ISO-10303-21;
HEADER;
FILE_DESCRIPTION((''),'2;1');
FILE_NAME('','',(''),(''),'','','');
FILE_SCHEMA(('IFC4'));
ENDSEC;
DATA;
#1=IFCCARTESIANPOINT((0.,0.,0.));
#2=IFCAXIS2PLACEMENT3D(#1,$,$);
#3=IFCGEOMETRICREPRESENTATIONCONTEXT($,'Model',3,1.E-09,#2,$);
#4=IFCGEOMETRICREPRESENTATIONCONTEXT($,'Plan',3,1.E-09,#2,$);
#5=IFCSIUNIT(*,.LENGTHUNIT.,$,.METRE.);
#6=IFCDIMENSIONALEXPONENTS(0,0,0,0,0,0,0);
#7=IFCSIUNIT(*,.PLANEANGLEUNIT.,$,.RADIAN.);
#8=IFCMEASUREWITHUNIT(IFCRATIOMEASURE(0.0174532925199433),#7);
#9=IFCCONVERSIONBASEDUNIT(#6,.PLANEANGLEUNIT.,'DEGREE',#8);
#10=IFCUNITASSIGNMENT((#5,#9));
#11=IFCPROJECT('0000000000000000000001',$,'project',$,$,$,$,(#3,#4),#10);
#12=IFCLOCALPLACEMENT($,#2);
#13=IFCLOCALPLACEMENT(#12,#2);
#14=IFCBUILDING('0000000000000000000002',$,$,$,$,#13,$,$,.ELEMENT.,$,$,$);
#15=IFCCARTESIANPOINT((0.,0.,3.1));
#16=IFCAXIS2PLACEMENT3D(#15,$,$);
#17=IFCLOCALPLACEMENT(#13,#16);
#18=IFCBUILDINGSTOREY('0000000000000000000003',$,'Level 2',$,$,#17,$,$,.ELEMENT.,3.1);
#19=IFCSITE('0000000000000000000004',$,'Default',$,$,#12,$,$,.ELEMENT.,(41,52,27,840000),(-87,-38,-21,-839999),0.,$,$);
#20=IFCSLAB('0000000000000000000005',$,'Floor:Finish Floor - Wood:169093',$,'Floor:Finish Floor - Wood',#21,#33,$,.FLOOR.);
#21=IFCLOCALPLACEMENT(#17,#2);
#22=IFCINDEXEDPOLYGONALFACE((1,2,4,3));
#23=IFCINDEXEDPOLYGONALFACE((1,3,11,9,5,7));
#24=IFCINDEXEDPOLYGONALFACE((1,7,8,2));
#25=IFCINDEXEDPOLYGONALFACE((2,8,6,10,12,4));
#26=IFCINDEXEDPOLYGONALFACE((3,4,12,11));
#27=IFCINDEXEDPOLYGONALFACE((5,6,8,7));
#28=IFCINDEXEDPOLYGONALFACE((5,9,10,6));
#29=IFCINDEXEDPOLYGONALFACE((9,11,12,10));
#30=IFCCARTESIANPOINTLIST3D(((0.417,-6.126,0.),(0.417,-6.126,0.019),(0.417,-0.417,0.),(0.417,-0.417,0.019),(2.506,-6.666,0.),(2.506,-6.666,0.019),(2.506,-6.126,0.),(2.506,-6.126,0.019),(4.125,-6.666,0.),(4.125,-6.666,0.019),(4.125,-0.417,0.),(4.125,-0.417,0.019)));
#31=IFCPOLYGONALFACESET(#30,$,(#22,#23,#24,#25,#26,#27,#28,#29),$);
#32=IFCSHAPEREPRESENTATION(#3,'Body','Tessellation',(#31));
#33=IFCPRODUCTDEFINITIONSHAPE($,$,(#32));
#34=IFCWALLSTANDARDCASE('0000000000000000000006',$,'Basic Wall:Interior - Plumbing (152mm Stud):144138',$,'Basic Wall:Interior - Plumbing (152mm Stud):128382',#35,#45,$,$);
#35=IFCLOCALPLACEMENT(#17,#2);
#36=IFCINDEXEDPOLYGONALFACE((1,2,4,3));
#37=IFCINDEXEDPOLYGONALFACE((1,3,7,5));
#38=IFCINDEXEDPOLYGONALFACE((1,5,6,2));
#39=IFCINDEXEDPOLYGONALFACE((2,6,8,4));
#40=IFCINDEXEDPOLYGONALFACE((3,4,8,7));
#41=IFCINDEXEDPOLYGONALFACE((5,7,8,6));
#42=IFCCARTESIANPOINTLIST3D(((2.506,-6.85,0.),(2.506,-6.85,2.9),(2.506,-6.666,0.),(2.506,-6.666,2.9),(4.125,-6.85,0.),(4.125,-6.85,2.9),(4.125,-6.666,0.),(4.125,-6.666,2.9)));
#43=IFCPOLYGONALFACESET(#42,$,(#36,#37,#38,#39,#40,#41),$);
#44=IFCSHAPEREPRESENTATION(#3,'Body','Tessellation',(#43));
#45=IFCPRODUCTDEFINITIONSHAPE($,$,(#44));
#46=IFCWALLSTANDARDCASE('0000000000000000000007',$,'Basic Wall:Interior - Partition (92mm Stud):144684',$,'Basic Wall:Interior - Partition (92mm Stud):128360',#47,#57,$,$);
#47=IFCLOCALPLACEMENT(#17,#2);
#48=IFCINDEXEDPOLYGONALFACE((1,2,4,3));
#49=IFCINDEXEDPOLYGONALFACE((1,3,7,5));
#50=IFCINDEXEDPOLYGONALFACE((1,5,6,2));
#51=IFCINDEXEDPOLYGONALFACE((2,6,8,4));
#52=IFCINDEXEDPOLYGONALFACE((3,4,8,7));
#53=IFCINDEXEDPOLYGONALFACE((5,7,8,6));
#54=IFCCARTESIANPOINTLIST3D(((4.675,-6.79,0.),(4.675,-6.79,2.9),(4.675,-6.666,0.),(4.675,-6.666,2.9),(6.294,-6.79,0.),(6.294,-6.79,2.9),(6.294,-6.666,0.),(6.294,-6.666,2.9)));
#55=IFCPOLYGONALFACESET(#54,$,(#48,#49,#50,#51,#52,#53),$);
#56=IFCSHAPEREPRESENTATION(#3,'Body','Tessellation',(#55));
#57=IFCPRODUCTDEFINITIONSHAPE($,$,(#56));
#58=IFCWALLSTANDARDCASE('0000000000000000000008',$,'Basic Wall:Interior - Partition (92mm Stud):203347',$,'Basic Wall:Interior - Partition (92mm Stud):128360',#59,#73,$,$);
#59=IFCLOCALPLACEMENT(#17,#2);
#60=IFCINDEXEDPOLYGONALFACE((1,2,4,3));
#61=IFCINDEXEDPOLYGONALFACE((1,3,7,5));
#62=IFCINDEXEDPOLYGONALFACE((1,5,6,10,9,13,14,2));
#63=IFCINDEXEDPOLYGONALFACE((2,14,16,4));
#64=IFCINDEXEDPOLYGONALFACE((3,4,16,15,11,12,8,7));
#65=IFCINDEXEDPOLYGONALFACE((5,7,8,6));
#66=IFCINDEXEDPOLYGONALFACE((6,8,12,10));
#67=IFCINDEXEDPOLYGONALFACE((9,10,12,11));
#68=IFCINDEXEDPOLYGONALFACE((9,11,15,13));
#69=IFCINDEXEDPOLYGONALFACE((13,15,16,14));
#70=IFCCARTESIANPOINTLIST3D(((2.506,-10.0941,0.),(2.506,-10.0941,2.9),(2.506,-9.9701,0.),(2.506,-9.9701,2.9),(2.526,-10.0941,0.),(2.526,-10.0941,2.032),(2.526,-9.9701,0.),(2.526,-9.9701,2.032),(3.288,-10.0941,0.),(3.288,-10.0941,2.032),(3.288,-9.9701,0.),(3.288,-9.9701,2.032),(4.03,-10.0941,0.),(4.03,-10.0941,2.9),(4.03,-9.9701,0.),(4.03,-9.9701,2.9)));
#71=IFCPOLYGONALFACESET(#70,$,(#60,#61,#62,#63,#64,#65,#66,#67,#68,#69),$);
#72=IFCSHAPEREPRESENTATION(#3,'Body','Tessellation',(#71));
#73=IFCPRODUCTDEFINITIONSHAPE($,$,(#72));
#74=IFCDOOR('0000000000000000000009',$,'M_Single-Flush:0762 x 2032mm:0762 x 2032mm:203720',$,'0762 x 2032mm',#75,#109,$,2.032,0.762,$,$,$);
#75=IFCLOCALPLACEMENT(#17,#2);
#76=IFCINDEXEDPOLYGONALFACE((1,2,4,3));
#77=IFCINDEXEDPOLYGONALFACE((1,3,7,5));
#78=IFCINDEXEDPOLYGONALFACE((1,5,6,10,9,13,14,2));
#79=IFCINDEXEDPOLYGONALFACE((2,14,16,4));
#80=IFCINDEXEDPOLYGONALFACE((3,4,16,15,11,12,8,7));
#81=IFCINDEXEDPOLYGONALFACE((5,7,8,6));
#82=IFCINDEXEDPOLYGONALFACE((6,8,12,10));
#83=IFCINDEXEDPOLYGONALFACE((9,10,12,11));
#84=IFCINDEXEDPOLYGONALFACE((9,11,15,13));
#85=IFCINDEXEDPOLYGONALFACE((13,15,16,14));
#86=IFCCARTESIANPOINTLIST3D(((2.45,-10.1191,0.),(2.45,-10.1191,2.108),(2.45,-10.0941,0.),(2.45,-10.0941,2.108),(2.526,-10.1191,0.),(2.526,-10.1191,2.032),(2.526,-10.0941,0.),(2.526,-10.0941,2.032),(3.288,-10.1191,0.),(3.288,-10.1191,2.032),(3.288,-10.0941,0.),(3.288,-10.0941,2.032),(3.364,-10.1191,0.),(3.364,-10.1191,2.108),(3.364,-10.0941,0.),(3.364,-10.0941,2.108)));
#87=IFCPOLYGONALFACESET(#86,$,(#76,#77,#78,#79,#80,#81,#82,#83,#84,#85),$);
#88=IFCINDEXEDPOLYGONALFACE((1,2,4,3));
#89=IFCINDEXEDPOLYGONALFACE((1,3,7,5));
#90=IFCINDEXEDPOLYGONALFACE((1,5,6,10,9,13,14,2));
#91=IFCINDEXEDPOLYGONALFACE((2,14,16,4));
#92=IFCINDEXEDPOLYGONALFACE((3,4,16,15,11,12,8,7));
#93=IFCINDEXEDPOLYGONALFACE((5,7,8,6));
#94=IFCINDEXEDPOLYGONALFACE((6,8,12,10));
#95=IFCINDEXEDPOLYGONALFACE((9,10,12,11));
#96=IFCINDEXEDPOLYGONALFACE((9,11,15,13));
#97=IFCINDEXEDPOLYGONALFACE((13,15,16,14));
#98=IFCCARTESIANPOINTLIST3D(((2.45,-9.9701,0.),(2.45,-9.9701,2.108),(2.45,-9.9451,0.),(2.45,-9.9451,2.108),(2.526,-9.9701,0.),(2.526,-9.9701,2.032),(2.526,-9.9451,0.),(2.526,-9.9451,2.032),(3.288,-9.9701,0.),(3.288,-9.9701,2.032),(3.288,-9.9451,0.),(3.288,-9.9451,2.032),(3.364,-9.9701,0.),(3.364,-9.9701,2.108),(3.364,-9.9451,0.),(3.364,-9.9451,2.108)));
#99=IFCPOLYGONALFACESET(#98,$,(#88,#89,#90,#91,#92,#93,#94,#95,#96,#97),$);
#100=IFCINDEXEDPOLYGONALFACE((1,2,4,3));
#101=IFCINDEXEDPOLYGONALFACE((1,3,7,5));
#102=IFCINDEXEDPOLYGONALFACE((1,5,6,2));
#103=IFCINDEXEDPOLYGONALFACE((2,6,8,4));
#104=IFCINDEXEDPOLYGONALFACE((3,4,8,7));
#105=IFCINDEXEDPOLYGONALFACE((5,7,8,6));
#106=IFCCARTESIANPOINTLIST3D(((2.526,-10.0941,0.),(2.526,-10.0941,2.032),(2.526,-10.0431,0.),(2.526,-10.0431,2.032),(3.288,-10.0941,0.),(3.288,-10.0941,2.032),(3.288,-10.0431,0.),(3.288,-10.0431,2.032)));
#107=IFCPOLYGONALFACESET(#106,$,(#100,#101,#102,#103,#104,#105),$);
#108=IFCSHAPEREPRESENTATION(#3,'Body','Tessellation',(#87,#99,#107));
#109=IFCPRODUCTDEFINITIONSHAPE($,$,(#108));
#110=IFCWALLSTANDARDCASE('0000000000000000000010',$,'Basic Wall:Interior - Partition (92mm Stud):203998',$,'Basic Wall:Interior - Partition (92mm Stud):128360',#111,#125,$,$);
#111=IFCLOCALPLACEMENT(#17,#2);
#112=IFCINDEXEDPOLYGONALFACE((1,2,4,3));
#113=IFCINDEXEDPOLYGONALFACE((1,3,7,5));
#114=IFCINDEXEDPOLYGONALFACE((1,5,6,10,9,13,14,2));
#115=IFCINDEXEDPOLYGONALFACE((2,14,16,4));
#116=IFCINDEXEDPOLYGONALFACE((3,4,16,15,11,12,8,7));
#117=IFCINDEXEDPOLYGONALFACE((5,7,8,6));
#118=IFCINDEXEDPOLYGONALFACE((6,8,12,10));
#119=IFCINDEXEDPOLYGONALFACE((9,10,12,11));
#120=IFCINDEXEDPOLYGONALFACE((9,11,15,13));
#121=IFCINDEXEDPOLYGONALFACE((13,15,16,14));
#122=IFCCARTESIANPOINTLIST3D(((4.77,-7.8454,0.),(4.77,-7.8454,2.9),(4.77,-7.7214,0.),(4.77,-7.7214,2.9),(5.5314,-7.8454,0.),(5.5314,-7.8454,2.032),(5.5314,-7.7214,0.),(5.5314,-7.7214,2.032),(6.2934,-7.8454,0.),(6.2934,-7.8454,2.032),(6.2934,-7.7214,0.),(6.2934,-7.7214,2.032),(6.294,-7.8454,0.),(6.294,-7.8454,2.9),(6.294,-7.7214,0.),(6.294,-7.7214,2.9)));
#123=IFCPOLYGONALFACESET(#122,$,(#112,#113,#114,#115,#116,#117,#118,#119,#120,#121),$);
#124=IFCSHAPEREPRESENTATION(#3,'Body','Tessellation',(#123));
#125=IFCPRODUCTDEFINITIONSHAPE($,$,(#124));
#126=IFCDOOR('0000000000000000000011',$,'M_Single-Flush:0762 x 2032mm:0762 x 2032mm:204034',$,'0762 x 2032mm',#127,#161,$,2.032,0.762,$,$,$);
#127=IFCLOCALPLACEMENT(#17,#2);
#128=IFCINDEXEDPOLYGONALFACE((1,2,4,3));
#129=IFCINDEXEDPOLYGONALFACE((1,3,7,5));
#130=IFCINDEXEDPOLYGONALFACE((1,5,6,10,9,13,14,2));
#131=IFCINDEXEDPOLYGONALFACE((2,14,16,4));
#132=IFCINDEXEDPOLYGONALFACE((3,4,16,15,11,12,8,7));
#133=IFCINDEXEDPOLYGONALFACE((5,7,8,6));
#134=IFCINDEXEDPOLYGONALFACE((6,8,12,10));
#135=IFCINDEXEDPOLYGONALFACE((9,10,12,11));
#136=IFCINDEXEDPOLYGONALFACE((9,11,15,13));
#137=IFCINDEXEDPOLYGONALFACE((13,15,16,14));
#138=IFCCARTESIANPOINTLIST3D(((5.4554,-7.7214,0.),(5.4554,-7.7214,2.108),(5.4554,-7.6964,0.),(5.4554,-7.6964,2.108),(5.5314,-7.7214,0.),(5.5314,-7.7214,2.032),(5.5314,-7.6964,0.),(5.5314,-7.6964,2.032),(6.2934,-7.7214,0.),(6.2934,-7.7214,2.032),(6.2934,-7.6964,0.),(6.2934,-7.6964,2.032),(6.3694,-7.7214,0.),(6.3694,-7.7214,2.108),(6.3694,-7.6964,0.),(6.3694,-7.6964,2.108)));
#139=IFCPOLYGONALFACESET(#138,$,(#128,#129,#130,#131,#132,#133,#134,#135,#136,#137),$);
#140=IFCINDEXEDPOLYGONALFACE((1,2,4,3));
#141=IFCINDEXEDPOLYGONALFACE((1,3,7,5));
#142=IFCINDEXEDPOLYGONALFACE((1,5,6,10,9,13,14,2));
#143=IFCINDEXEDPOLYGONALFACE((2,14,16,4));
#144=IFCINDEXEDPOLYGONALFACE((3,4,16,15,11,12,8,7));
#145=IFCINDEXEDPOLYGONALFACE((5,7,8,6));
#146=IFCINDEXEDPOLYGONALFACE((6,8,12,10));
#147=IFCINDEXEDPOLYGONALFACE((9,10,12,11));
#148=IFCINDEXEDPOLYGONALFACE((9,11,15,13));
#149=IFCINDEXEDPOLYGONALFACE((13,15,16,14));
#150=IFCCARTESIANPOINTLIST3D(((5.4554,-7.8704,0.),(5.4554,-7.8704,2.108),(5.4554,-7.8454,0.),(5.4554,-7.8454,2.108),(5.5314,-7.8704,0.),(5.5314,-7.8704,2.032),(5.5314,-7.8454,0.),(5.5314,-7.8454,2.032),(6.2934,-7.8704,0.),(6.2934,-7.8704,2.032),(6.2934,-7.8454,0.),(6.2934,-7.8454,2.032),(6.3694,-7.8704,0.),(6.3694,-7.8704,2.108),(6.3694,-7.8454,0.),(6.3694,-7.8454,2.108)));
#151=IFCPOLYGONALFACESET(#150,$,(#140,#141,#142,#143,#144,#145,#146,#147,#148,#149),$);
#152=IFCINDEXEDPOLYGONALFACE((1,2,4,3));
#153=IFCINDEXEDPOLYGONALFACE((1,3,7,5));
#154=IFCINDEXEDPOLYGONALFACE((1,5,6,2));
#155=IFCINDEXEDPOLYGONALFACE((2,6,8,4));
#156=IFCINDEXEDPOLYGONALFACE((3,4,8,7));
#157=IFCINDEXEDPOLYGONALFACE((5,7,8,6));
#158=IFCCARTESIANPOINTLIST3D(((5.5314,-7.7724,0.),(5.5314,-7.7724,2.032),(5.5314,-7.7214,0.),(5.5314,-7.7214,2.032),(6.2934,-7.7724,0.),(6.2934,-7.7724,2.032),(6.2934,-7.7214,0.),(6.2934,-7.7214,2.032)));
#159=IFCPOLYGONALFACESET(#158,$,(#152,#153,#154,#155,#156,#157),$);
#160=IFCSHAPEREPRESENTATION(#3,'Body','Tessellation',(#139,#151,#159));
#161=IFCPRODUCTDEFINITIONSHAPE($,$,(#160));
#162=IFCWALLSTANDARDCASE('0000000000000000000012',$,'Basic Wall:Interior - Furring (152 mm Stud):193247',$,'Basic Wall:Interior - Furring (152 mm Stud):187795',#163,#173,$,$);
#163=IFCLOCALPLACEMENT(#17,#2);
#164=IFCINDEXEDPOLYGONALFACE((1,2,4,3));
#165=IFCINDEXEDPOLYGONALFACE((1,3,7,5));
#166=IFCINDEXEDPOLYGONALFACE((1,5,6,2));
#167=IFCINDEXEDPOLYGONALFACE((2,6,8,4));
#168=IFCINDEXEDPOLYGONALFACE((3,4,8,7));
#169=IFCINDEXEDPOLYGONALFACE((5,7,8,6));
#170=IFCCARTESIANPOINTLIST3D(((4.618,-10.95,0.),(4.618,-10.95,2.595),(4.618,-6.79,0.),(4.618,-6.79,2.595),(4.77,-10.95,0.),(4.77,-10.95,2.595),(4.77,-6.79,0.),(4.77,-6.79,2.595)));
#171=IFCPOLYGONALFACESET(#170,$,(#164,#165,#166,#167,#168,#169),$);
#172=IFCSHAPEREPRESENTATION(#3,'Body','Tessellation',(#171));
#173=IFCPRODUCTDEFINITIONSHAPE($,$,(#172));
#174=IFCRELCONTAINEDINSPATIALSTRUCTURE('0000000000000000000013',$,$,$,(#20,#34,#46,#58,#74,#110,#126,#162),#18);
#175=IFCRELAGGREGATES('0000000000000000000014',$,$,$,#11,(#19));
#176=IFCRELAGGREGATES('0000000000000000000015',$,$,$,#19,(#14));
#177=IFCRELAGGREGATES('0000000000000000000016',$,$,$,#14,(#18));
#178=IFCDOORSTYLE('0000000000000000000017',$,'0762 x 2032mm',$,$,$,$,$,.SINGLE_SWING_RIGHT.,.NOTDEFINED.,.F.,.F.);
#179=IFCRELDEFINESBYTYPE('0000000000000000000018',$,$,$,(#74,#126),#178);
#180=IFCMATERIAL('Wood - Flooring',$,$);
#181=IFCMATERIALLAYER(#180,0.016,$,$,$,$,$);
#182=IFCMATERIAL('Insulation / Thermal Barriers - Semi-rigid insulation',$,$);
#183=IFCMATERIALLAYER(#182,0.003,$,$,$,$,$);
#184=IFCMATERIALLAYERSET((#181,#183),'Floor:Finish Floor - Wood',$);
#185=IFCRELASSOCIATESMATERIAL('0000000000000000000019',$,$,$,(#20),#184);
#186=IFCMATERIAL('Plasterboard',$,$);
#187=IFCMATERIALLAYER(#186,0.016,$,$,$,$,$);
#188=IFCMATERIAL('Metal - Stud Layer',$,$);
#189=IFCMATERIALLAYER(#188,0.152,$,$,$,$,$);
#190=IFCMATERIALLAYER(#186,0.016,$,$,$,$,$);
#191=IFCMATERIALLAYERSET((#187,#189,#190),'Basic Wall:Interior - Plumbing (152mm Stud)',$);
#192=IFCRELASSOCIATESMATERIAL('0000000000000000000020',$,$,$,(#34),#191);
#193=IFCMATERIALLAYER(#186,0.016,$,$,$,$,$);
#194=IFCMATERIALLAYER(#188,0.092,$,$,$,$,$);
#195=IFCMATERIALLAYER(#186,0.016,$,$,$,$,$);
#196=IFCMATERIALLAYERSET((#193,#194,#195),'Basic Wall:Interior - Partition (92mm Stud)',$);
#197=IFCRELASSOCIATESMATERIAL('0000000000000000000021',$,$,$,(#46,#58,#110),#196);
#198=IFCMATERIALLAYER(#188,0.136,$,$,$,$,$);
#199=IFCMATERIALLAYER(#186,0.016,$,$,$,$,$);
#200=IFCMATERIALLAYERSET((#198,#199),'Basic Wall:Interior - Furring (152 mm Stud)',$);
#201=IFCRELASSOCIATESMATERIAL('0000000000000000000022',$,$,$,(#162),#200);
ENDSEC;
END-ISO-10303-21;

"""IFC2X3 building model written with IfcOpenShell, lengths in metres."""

from ifc_helpers import new_model, entity, si_unit, converted_unit, frame, frame_2d, origin, origin_2d_with_axis, place, context, project, spatial, polyline, rectangle, outline, extrude, source, transform, mapped, material, layer, layer_set, layer_usage, type_object, type_shapes, element, fill, save


model = new_model("IFC2X3")

# Units and contexts
model_context = context("Model", 3, precision=1e-09, world=origin())
plan_context = context("Plan", 3, precision=1e-09, world=origin())
ifc_project = project(units=[si_unit("LENGTHUNIT", "METRE"), converted_unit("PLANEANGLEUNIT", "DEGREE", entity("IfcRatioMeasure", 0.0174532925199433), si_unit("PLANEANGLEUNIT", "RADIAN"), dimensions=[0, 0, 0, 0, 0, 0, 0])], contexts=[model_context, plan_context])

# Site, building, storey
site_placement = place(None, origin())
site = spatial("IfcSite", under=ifc_project, at=site_placement, Name="Default", CompositionType="ELEMENT", RefLatitude=(41, 52, 27, 840000), RefLongitude=(-87, -38, -21, -839999), RefElevation=0.0)
building_placement = place(site_placement, origin())
building = spatial("IfcBuilding", under=site, at=building_placement, CompositionType="ELEMENT")
storey_placement = place(building_placement, frame((0.0, 0.0, 3.1)))
storey = spatial("IfcBuildingStorey", under=building, at=storey_placement, Name="Level 2", CompositionType="ELEMENT", Elevation=3.1)

# Slab
ifc_material_1 = material(Name="Wood - Flooring")
ifc_layer_1 = layer(ifc_material_1, 0.016)
ifc_material_2 = material(Name="Insulation / Thermal Barriers - Semi-rigid insulation")
ifc_layer_2 = layer(ifc_material_2, 0.003)
ifc_layer_set_1 = layer_set([ifc_layer_1, ifc_layer_2], Name="Floor:Finish Floor - Wood")
ifc_layer_usage_1 = layer_usage(ifc_layer_set_1, "AXIS3", "POSITIVE", 0.0)
slab_placement = place(storey_placement, frame((0.417, -6.666, 0.0)))
element("IfcSlab", 1, at=slab_placement, inside=storey, material=ifc_layer_usage_1, Name="Floor:Finish Floor - Wood:169093", ObjectType="Floor:Finish Floor - Wood", PredefinedType="FLOOR", context=model_context, shape_type="SweptSolid", body=[
    extrude(outline(polyline([(1.854, 3.1245), (-1.854, 3.1245), (-1.854, -3.1245), (-0.235, -3.1245), (-0.235, -2.5845), (1.854, -2.5845), (1.854, 3.1245)])), frame((1.854, 3.1245, 0.019), z_axis=(0.0, 0.0, -1.0), x_axis=(-1.0, 0.0, 0.0)), (0.0, 0.0, 1.0), 0.019),
])

# Walls
ifc_material_3 = material(Name="Plasterboard")
ifc_layer_3 = layer(ifc_material_3, 0.016)
ifc_material_4 = material(Name="Metal - Stud Layer")
ifc_layer_4 = layer(ifc_material_4, 0.152)
ifc_layer_5 = layer(ifc_material_3, 0.016)
ifc_layer_set_2 = layer_set([ifc_layer_3, ifc_layer_4, ifc_layer_5], Name="Basic Wall:Interior - Plumbing (152mm Stud)")
ifc_layer_usage_2 = layer_usage(ifc_layer_set_2, "AXIS2", "NEGATIVE", 0.092)
wall_1_placement = place(storey_placement, frame((2.506, -6.758, 0.0)))
element("IfcWallStandardCase", 2, at=wall_1_placement, inside=storey, material=ifc_layer_usage_2, Name="Basic Wall:Interior - Plumbing (152mm Stud):144138", ObjectType="Basic Wall:Interior - Plumbing (152mm Stud):128382", context=model_context, shape_type="SweptSolid", body=[
    extrude(rectangle(XDim=1.619, YDim=0.184, at=frame_2d((0.8095, 0.0), x_axis=(-1.0, 0.0))), origin(), (0.0, 0.0, 1.0), 2.9),
])
ifc_layer_6 = layer(ifc_material_3, 0.016)
ifc_layer_7 = layer(ifc_material_4, 0.092)
ifc_layer_8 = layer(ifc_material_3, 0.016)
ifc_layer_set_3 = layer_set([ifc_layer_6, ifc_layer_7, ifc_layer_8], Name="Basic Wall:Interior - Partition (92mm Stud)")
ifc_layer_usage_3 = layer_usage(ifc_layer_set_3, "AXIS2", "NEGATIVE", 0.062)
wall_2_placement = place(storey_placement, frame((4.675, -6.728, 0.0)))
element("IfcWallStandardCase", 3, at=wall_2_placement, inside=storey, material=ifc_layer_usage_3, Name="Basic Wall:Interior - Partition (92mm Stud):144684", ObjectType="Basic Wall:Interior - Partition (92mm Stud):128360", context=model_context, shape_type="SweptSolid", body=[
    extrude(rectangle(XDim=1.619, YDim=0.124, at=frame_2d((0.8095, 0.0), x_axis=(-1.0, 0.0))), origin(), (0.0, 0.0, 1.0), 2.9),
])

# Walls, openings, doors
wall_3_placement = place(storey_placement, frame((4.03, -10.0321, 0.0), z_axis=(0.0, 0.0, 1.0), x_axis=(-1.0, 0.0, 0.0)))
wall_3 = element("IfcWallStandardCase", 4, at=wall_3_placement, inside=storey, material=ifc_layer_usage_3, Name="Basic Wall:Interior - Partition (92mm Stud):203347", ObjectType="Basic Wall:Interior - Partition (92mm Stud):128360", context=model_context, shape_type="SweptSolid", body=[
    extrude(rectangle(XDim=1.524, YDim=0.124, at=frame_2d((0.762, 0.0), x_axis=(-1.0, 0.0))), origin(), (0.0, 0.0, 1.0), 2.9),
])
opening_1_placement = place(wall_3_placement, frame((0.742, -0.062, 0.0)))
opening_1 = element("IfcOpeningElement", 5, at=opening_1_placement, cuts=wall_3, ObjectType="Opening", context=model_context, shape_type="SweptSolid", body=[
    extrude(rectangle(XDim=0.762, YDim=2.032, at=frame_2d((1.016, 0.381), x_axis=(0.0, 1.0))), frame((0.0, 0.0, 0.0), z_axis=(0.0, 1.0, 0.0), x_axis=(0.0, 0.0, 1.0)), (0.0, 0.0, 1.0), 0.124),
])
door_style = type_object("IfcDoorStyle", Name="0762 x 2032mm", ConstructionType="NOTDEFINED", OperationType="SINGLE_SWING_RIGHT", ParameterTakesPrecedence=False, Sizeable=False)
shared_shape = source(origin(), model_context, "Body", "SweptSolid", [
    extrude(outline(polyline([(-0.457, -1.073), (0.457, -1.073), (0.457, 1.035), (0.381, 1.035), (0.381, -0.997), (-0.381, -0.997), (-0.381, 1.035), (-0.457, 1.035), (-0.457, -1.073)])), frame((0.381, 0.124, 1.035), z_axis=(0.0, 1.0, 0.0), x_axis=(1.0, 0.0, 0.0)), (0.0, 0.0, 1.0), 0.025),
    extrude(outline(polyline([(-1.073, -0.457), (1.035, -0.457), (1.035, -0.381), (-0.997, -0.381), (-0.997, 0.381), (1.035, 0.381), (1.035, 0.457), (-1.073, 0.457), (-1.073, -0.457)])), frame((0.381, -0.025, 1.035), z_axis=(0.0, 1.0, 0.0), x_axis=(0.0, 0.0, -1.0)), (0.0, 0.0, 1.0), 0.025),
    extrude(rectangle(XDim=0.051, YDim=0.762, at=origin_2d_with_axis()), frame((0.381, 0.0985, 0.0), z_axis=(0.0, 0.0, 1.0), x_axis=(0.0, 1.0, 0.0)), (0.0, 0.0, 1.0), 2.032),
])
type_shapes(door_style, [shared_shape])
door_1_placement = place(opening_1_placement, origin())
door_1 = element("IfcDoor", 6, at=door_1_placement, inside=storey, type_object=door_style, Name="M_Single-Flush:0762 x 2032mm:0762 x 2032mm:203720", ObjectType="0762 x 2032mm", OverallHeight=2.032, OverallWidth=0.762, context=model_context, shape_type="MappedRepresentation", body=[
    mapped(shared_shape, transform((0.0, 0.0, 0.0), scale=1.0)),
])
fill(opening_1, door_1)
ifc_layer_usage_4 = layer_usage(ifc_layer_set_3, "AXIS2", "POSITIVE", -0.062)
wall_4_placement = place(storey_placement, frame((4.77, -7.7834, 0.0)))
wall_4 = element("IfcWallStandardCase", 7, at=wall_4_placement, inside=storey, material=ifc_layer_usage_4, Name="Basic Wall:Interior - Partition (92mm Stud):203998", ObjectType="Basic Wall:Interior - Partition (92mm Stud):128360", context=model_context, shape_type="SweptSolid", body=[
    extrude(rectangle(XDim=1.524, YDim=0.124, at=frame_2d((0.762, 0.0), x_axis=(-1.0, 0.0))), origin(), (0.0, 0.0, 1.0), 2.9),
])
opening_2_placement = place(wall_4_placement, frame((0.7614, -0.062, 0.0)))
opening_2 = element("IfcOpeningElement", 8, at=opening_2_placement, cuts=wall_4, ObjectType="Opening", context=model_context, shape_type="SweptSolid", body=[
    extrude(rectangle(XDim=0.762, YDim=2.032, at=frame_2d((1.016, 0.381), x_axis=(0.0, 1.0))), frame((0.0, 0.0, 0.0), z_axis=(0.0, 1.0, 0.0), x_axis=(0.0, 0.0, 1.0)), (0.0, 0.0, 1.0), 0.124),
])
door_2_placement = place(opening_2_placement, origin())
door_2 = element("IfcDoor", 9, at=door_2_placement, inside=storey, type_object=door_style, Name="M_Single-Flush:0762 x 2032mm:0762 x 2032mm:204034", ObjectType="0762 x 2032mm", OverallHeight=2.032, OverallWidth=0.762, context=model_context, shape_type="MappedRepresentation", body=[
    mapped(shared_shape, transform((0.0, 0.0, 0.0), scale=1.0)),
])
fill(opening_2, door_2)

# Wall
ifc_layer_9 = layer(ifc_material_4, 0.136)
ifc_layer_10 = layer(ifc_material_3, 0.016)
ifc_layer_set_4 = layer_set([ifc_layer_9, ifc_layer_10], Name="Basic Wall:Interior - Furring (152 mm Stud)")
ifc_layer_usage_5 = layer_usage(ifc_layer_set_4, "AXIS2", "POSITIVE", -0.076)
wall_5_placement = place(storey_placement, frame((4.694, -6.79, 0.0), z_axis=(0.0, 0.0, 1.0), x_axis=(0.0, -1.0, 0.0)))
element("IfcWallStandardCase", 10, at=wall_5_placement, inside=storey, material=ifc_layer_usage_5, Name="Basic Wall:Interior - Furring (152 mm Stud):193247", ObjectType="Basic Wall:Interior - Furring (152 mm Stud):187795", context=model_context, shape_type="SweptSolid", body=[
    extrude(rectangle(XDim=4.16, YDim=0.152, at=frame_2d((2.08, 0.0), x_axis=(-1.0, 0.0))), origin(), (0.0, 0.0, 1.0), 2.595),
])

save(model, "model.ifc")
